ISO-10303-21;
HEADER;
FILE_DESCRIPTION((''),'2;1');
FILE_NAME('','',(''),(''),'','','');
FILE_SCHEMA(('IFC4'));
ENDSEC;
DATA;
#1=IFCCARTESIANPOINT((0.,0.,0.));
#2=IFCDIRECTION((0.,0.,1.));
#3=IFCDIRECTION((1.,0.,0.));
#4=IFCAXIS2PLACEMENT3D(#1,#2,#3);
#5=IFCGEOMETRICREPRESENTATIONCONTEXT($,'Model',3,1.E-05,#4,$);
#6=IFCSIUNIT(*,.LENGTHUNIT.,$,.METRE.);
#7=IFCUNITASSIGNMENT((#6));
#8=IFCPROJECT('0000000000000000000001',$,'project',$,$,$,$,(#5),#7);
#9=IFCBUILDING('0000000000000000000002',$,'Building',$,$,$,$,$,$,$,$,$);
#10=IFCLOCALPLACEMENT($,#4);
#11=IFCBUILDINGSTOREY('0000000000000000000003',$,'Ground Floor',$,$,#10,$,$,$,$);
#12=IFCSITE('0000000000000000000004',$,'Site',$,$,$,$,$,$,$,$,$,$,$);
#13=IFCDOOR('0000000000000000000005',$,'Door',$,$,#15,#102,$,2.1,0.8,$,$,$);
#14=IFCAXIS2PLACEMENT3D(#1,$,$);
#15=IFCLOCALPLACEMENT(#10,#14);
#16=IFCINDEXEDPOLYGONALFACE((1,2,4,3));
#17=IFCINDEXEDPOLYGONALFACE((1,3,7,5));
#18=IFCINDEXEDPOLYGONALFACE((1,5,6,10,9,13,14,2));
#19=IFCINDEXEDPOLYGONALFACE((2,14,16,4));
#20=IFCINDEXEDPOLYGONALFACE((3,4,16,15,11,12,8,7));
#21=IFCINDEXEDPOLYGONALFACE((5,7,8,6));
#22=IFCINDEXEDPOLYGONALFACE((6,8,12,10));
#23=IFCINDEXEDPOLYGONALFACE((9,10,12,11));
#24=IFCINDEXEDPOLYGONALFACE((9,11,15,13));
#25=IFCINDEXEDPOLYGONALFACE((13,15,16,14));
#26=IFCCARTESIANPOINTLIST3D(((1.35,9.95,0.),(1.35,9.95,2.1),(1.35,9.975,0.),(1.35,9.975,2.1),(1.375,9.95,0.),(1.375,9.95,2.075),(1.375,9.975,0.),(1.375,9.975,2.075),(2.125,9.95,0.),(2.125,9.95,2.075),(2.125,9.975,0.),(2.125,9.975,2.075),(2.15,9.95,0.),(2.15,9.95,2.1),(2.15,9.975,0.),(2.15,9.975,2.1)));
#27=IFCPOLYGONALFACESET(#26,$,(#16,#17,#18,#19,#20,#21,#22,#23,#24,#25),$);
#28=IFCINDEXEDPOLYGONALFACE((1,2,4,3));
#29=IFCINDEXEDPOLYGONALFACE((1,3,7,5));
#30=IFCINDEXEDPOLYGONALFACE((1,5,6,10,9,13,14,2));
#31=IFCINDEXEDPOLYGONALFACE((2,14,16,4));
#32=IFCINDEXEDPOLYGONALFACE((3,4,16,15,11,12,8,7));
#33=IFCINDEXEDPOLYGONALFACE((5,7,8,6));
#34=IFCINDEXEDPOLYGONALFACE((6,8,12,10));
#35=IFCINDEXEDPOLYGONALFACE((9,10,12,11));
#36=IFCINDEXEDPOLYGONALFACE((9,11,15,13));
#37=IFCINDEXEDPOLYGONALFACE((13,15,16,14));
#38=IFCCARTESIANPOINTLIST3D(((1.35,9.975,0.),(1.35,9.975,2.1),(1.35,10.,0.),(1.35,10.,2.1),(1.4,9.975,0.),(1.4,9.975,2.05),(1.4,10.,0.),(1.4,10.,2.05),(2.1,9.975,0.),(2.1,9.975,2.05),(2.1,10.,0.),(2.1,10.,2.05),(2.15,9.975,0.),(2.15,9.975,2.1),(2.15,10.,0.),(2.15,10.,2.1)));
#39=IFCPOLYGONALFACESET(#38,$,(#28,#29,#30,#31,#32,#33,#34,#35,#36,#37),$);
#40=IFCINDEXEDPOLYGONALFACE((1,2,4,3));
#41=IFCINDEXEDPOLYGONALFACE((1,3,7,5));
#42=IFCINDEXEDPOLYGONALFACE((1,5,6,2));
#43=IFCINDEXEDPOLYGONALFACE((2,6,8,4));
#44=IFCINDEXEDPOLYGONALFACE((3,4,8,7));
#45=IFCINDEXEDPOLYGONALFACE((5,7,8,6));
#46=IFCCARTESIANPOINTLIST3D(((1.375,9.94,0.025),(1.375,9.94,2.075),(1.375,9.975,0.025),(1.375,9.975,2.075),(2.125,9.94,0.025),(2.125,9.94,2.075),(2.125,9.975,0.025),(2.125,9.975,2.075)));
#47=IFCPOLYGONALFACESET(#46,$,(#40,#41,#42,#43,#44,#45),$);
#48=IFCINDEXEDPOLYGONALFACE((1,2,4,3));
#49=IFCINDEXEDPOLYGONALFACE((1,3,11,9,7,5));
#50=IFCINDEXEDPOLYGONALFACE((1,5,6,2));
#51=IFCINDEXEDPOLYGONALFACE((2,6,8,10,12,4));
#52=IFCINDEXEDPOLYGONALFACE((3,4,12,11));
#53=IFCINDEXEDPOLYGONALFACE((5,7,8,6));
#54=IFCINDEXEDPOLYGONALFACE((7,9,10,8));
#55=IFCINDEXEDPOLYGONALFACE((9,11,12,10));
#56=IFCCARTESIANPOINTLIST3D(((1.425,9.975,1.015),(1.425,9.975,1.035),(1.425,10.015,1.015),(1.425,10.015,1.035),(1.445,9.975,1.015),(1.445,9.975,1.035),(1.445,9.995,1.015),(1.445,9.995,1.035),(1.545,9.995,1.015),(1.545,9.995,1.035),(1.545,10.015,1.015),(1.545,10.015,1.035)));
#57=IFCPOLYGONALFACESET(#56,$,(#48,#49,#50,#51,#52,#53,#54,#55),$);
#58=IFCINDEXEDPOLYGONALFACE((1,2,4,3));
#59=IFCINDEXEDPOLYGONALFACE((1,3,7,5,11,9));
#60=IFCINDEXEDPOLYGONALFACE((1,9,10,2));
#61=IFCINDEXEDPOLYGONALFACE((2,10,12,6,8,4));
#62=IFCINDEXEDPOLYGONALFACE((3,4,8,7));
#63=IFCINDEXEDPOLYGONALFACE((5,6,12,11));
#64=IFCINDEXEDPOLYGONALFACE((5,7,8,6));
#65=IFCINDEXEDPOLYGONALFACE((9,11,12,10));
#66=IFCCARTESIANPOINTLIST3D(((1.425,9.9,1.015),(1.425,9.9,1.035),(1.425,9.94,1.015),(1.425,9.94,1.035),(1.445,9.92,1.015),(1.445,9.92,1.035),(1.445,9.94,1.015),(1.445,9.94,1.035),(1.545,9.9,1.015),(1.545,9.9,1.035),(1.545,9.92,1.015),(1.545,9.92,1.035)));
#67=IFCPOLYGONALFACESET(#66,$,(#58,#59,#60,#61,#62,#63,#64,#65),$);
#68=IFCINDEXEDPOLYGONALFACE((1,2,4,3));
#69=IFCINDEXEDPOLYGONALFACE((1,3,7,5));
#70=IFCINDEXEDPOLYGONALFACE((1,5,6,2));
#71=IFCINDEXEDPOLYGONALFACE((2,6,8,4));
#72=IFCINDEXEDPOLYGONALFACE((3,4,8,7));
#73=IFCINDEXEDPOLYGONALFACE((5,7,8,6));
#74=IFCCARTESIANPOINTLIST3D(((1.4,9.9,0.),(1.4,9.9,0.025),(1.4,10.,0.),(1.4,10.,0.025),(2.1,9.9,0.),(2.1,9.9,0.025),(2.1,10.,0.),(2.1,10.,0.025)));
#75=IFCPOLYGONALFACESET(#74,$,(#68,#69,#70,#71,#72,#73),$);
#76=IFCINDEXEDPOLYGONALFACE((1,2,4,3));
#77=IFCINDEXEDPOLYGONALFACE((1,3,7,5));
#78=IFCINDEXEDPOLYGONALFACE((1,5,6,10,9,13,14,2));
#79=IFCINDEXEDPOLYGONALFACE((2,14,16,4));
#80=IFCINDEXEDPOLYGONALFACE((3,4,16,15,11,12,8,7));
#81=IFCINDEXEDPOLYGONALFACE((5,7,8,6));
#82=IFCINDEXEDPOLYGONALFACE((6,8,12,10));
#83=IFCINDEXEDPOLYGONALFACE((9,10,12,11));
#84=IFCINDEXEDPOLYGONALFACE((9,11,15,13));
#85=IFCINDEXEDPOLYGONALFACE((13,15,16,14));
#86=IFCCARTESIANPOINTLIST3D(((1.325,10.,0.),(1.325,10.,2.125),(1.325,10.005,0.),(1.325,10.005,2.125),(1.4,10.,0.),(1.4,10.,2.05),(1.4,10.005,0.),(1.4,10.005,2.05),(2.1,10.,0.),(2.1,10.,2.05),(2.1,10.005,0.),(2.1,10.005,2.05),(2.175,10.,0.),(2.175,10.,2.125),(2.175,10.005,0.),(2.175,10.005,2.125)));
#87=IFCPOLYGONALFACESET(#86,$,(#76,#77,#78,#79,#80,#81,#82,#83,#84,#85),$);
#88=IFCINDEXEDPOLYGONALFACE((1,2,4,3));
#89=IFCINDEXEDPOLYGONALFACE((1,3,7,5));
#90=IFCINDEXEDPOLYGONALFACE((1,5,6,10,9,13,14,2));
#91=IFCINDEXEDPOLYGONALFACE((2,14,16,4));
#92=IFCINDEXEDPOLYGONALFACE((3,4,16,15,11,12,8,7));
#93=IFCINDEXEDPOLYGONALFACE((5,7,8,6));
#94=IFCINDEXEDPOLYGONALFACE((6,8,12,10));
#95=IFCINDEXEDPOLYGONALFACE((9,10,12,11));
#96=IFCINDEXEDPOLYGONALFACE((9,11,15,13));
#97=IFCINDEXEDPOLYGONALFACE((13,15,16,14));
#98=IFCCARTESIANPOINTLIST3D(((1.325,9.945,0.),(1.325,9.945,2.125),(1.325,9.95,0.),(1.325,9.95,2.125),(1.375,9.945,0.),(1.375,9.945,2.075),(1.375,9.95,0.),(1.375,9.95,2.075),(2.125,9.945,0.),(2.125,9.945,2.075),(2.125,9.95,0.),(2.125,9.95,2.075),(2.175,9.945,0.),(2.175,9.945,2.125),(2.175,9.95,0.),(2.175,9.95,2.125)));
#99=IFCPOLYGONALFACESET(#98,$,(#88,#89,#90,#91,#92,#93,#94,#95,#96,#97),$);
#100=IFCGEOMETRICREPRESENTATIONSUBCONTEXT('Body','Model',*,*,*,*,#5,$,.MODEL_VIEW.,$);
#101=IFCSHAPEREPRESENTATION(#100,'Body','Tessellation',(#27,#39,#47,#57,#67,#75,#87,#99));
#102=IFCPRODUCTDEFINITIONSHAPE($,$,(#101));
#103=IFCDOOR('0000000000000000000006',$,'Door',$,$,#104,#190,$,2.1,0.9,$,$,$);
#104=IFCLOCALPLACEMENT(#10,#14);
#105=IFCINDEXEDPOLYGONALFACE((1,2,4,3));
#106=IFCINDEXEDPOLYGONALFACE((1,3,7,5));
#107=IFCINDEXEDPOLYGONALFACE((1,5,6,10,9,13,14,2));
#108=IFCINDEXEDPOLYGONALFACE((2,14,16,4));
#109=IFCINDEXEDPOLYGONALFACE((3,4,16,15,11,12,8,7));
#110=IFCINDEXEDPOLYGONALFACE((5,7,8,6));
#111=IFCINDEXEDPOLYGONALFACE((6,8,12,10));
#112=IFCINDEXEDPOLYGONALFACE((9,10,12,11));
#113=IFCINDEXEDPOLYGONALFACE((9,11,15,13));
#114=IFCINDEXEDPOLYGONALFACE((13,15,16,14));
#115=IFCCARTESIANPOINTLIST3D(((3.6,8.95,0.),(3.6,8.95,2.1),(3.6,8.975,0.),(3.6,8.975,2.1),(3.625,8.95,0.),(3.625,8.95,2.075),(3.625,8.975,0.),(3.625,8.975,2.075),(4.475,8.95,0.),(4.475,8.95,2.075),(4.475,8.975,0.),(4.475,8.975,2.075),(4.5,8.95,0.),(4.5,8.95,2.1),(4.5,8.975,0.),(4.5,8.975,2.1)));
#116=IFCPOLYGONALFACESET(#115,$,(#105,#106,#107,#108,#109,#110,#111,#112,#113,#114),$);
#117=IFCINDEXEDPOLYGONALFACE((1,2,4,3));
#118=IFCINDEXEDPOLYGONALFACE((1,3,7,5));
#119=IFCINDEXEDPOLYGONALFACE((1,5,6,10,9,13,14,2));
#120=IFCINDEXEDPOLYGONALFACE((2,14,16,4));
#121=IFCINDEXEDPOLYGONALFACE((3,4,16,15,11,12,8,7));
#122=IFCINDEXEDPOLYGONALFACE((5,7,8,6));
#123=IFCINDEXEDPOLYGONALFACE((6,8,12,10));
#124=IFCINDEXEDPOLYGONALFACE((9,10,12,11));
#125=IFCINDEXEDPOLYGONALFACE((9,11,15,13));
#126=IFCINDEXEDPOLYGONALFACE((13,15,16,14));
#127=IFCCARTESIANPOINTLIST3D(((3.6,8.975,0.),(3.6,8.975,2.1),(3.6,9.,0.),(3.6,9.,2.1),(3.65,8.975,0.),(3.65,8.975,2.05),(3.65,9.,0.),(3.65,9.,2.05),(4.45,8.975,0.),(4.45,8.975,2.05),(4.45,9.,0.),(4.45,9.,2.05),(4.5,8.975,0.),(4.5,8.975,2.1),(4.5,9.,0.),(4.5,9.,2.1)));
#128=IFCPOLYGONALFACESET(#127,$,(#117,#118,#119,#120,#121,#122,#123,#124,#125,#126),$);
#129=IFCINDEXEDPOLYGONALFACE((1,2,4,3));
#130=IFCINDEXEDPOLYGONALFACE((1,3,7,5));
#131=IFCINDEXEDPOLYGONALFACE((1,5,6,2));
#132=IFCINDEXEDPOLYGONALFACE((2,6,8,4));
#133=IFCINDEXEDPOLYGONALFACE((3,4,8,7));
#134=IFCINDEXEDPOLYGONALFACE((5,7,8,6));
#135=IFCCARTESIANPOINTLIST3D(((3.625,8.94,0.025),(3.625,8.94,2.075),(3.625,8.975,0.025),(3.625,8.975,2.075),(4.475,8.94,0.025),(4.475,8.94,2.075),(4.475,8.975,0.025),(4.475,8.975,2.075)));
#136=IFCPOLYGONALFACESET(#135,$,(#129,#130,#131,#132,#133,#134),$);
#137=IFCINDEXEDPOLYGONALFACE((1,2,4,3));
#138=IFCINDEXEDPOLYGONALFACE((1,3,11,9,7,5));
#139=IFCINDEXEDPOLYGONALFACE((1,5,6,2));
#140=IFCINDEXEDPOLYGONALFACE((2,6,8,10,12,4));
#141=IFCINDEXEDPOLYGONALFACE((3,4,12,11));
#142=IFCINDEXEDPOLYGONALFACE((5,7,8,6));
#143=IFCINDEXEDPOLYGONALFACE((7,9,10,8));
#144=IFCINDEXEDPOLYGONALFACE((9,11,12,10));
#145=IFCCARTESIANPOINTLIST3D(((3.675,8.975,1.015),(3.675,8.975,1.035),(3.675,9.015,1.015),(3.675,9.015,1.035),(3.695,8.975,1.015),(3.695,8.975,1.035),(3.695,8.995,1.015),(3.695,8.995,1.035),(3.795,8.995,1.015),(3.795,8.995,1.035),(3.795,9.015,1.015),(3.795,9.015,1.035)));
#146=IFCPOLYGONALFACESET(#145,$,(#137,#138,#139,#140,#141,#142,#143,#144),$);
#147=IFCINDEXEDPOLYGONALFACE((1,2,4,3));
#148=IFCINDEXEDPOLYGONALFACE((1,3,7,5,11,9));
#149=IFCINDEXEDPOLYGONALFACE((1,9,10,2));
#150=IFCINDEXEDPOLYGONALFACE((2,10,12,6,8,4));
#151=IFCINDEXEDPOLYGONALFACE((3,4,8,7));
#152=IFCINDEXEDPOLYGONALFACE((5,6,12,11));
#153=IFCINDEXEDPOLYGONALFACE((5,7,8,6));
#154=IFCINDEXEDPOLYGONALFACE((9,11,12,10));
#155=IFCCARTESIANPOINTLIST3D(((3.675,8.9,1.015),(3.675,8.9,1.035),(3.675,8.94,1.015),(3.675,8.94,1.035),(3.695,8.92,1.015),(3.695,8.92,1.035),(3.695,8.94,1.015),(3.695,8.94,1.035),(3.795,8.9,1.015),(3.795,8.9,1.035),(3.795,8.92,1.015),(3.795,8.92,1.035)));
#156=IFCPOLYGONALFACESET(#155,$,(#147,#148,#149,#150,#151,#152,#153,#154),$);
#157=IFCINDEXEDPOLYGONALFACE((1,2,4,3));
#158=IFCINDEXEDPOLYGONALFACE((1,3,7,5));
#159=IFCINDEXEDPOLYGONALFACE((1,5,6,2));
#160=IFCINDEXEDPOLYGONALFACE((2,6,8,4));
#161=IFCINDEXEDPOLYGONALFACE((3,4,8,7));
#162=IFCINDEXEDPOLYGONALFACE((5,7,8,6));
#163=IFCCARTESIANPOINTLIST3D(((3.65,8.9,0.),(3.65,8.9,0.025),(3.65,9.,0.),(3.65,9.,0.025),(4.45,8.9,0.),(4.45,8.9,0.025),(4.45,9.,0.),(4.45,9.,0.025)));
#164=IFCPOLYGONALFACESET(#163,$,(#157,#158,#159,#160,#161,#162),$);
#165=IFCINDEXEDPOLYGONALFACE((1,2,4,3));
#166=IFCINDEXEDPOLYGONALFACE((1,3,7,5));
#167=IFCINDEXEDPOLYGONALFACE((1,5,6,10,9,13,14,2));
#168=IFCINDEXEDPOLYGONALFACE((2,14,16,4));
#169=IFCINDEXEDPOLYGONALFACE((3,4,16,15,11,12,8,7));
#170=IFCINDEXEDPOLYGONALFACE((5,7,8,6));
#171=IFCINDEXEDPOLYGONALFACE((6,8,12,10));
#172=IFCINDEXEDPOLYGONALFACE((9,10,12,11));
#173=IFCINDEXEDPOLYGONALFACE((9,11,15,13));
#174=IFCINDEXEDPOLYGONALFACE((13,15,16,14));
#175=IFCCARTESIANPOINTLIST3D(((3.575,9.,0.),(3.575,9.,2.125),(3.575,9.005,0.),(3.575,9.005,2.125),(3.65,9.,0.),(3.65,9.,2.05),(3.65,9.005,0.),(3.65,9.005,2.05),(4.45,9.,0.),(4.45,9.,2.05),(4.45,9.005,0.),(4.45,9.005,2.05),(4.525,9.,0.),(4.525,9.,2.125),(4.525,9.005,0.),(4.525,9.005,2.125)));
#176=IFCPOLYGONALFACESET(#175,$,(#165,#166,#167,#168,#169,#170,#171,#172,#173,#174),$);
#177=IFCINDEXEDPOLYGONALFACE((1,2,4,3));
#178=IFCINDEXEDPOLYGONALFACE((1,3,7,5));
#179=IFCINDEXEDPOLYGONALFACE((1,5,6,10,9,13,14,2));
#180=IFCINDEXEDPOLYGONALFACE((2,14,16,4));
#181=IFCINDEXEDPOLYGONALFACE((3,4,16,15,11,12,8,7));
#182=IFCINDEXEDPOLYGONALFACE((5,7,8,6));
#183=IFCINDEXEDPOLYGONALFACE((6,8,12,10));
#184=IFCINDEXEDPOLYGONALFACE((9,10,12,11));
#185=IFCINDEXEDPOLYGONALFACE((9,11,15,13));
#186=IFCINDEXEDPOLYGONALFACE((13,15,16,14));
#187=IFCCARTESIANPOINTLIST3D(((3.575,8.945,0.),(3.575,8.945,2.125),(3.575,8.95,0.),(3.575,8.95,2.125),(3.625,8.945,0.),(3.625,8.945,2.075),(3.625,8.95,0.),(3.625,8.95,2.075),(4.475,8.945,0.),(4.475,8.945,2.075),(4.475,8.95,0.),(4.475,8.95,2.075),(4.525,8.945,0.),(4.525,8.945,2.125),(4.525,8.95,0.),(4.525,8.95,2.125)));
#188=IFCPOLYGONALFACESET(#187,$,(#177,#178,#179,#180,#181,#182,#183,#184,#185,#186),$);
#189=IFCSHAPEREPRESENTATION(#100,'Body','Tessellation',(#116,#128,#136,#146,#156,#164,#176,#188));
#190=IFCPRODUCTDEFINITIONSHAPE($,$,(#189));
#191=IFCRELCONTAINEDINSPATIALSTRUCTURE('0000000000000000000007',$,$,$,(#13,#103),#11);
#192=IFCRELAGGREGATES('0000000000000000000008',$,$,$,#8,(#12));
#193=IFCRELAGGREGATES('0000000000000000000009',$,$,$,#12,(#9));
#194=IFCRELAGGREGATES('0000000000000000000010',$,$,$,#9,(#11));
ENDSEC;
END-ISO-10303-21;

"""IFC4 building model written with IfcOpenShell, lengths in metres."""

from ifc_helpers import new_model, si_unit, frame, origin_with_axes, place, context, subcontext, project, spatial, line, indexed_curve, outline, extrude, element, save


model = new_model("IFC4")

# Units and contexts
model_context = context("Model", 3, precision=1e-05, world=origin_with_axes())
body_context = subcontext(model_context, "Body", "Model", "MODEL_VIEW")
ifc_project = project(units=[si_unit("LENGTHUNIT", "METRE")], contexts=[model_context])

# Site, building, storey
site = spatial("IfcSite", under=ifc_project, Name="Site")
building = spatial("IfcBuilding", under=site, Name="Building")
storey_placement = place(None, origin_with_axes())
storey = spatial("IfcBuildingStorey", under=building, at=storey_placement, Name="Ground Floor")

# Doors
door_1_placement = place(storey_placement, frame((2.15, 10.0, 0.0), z_axis=(0.0, 0.0, 1.0), x_axis=(-1.0, 0.0, 0.0)))
element("IfcDoor", 1, at=door_1_placement, inside=storey, Name="Door", OverallHeight=2.1, OverallWidth=0.8, context=body_context, shape_type="SweptSolid", body=[
    extrude(outline(indexed_curve([(0.0, 0.0), (0.0, 2.1), (0.8, 2.1), (0.8, 0.0), (0.775, 0.0), (0.775, 2.075), (0.025, 2.075), (0.025, 0.0)], segments=[line(1, 2, 3, 4, 5, 6, 7, 8, 1)])), frame((0.0, 0.025, 0.0), z_axis=(0.0, -1.0, 0.0), x_axis=(1.0, 0.0, 0.0)), (0.0, 0.0, -1.0), 0.025),
    extrude(outline(indexed_curve([(0.0, 0.0), (0.0, 2.1), (0.8, 2.1), (0.8, 0.0), (0.75, 0.0), (0.75, 2.05), (0.05, 2.05), (0.05, 0.0)], segments=[line(1, 2, 3, 4, 5, 6, 7, 8, 1)])), frame((0.0, 0.0, 0.0), z_axis=(0.0, -1.0, 0.0), x_axis=(1.0, 0.0, 0.0)), (0.0, 0.0, -1.0), 0.025),
    extrude(outline(indexed_curve([(0.0, 0.0), (0.75, 0.0), (0.75, 0.035), (0.0, 0.035)], segments=[line(1, 2, 3, 4, 1)])), frame((0.025, 0.025, 0.025), z_axis=(0.0, 0.0, 1.0), x_axis=(1.0, 0.0, 0.0)), (0.0, 0.0, 1.0), 2.05),
    extrude(outline(indexed_curve([(0.0, 0.0), (0.0, -0.04), (-0.12, -0.04), (-0.12, -0.02), (-0.02, -0.02), (-0.02, 0.0)], segments=[line(1, 2, 3, 4, 5, 6, 1)])), frame((0.725, 0.025, 1.015), z_axis=(0.0, 0.0, 1.0), x_axis=(1.0, 0.0, 0.0)), (0.0, 0.0, 1.0), 0.02),
    extrude(outline(indexed_curve([(0.0, 0.0), (0.0, 0.04), (-0.12, 0.04), (-0.12, 0.02), (-0.02, 0.02), (-0.02, 0.0)], segments=[line(1, 2, 3, 4, 5, 6, 1)])), frame((0.725, 0.06, 1.015), z_axis=(0.0, 0.0, 1.0), x_axis=(1.0, 0.0, 0.0)), (0.0, 0.0, 1.0), 0.02),
    extrude(outline(indexed_curve([(0.0, 0.0), (0.7, 0.0), (0.7, 0.1), (0.0, 0.1)], segments=[line(1, 2, 3, 4, 1)])), frame((0.05, 0.0, 0.0), z_axis=(0.0, 0.0, 1.0), x_axis=(1.0, 0.0, 0.0)), (0.0, 0.0, 1.0), 0.025),
    extrude(outline(indexed_curve([(0.0, 0.0), (0.0, 2.125), (0.85, 2.125), (0.85, 0.0), (0.775, 0.0), (0.775, 2.05), (0.075, 2.05), (0.075, 0.0)], segments=[line(1, 2, 3, 4, 5, 6, 7, 8, 1)])), frame((-0.025, -0.005, 0.0), z_axis=(0.0, -1.0, 0.0), x_axis=(1.0, 0.0, 0.0)), (0.0, 0.0, -1.0), 0.005),
    extrude(outline(indexed_curve([(0.0, 0.0), (0.0, 2.125), (0.85, 2.125), (0.85, 0.0), (0.8, 0.0), (0.8, 2.075), (0.05, 2.075), (0.05, 0.0)], segments=[line(1, 2, 3, 4, 5, 6, 7, 8, 1)])), frame((-0.025, 0.05, 0.0), z_axis=(0.0, -1.0, 0.0), x_axis=(1.0, 0.0, 0.0)), (0.0, 0.0, -1.0), 0.005),
])
door_2_placement = place(storey_placement, frame((4.5, 9.0, 0.0), z_axis=(0.0, 0.0, 1.0), x_axis=(-1.0, 0.0, 0.0)))
element("IfcDoor", 2, at=door_2_placement, inside=storey, Name="Door", OverallHeight=2.1, OverallWidth=0.9, context=body_context, shape_type="SweptSolid", body=[
    extrude(outline(indexed_curve([(0.0, 0.0), (0.0, 2.1), (0.9, 2.1), (0.9, 0.0), (0.875, 0.0), (0.875, 2.075), (0.025, 2.075), (0.025, 0.0)], segments=[line(1, 2, 3, 4, 5, 6, 7, 8, 1)])), frame((0.0, 0.025, 0.0), z_axis=(0.0, -1.0, 0.0), x_axis=(1.0, 0.0, 0.0)), (0.0, 0.0, -1.0), 0.025),
    extrude(outline(indexed_curve([(0.0, 0.0), (0.0, 2.1), (0.9, 2.1), (0.9, 0.0), (0.85, 0.0), (0.85, 2.05), (0.05, 2.05), (0.05, 0.0)], segments=[line(1, 2, 3, 4, 5, 6, 7, 8, 1)])), frame((0.0, 0.0, 0.0), z_axis=(0.0, -1.0, 0.0), x_axis=(1.0, 0.0, 0.0)), (0.0, 0.0, -1.0), 0.025),
    extrude(outline(indexed_curve([(0.0, 0.0), (0.85, 0.0), (0.85, 0.035), (0.0, 0.035)], segments=[line(1, 2, 3, 4, 1)])), frame((0.025, 0.025, 0.025), z_axis=(0.0, 0.0, 1.0), x_axis=(1.0, 0.0, 0.0)), (0.0, 0.0, 1.0), 2.05),
    extrude(outline(indexed_curve([(0.0, 0.0), (0.0, -0.04), (-0.12, -0.04), (-0.12, -0.02), (-0.02, -0.02), (-0.02, 0.0)], segments=[line(1, 2, 3, 4, 5, 6, 1)])), frame((0.825, 0.025, 1.015), z_axis=(0.0, 0.0, 1.0), x_axis=(1.0, 0.0, 0.0)), (0.0, 0.0, 1.0), 0.02),
    extrude(outline(indexed_curve([(0.0, 0.0), (0.0, 0.04), (-0.12, 0.04), (-0.12, 0.02), (-0.02, 0.02), (-0.02, 0.0)], segments=[line(1, 2, 3, 4, 5, 6, 1)])), frame((0.825, 0.06, 1.015), z_axis=(0.0, 0.0, 1.0), x_axis=(1.0, 0.0, 0.0)), (0.0, 0.0, 1.0), 0.02),
    extrude(outline(indexed_curve([(0.0, 0.0), (0.8, 0.0), (0.8, 0.1), (0.0, 0.1)], segments=[line(1, 2, 3, 4, 1)])), frame((0.05, 0.0, 0.0), z_axis=(0.0, 0.0, 1.0), x_axis=(1.0, 0.0, 0.0)), (0.0, 0.0, 1.0), 0.025),
    extrude(outline(indexed_curve([(0.0, 0.0), (0.0, 2.125), (0.95, 2.125), (0.95, 0.0), (0.875, 0.0), (0.875, 2.05), (0.075, 2.05), (0.075, 0.0)], segments=[line(1, 2, 3, 4, 5, 6, 7, 8, 1)])), frame((-0.025, -0.005, 0.0), z_axis=(0.0, -1.0, 0.0), x_axis=(1.0, 0.0, 0.0)), (0.0, 0.0, -1.0), 0.005),
    extrude(outline(indexed_curve([(0.0, 0.0), (0.0, 2.125), (0.95, 2.125), (0.95, 0.0), (0.9, 0.0), (0.9, 2.075), (0.05, 2.075), (0.05, 0.0)], segments=[line(1, 2, 3, 4, 5, 6, 7, 8, 1)])), frame((-0.025, 0.05, 0.0), z_axis=(0.0, -1.0, 0.0), x_axis=(1.0, 0.0, 0.0)), (0.0, 0.0, -1.0), 0.005),
])

save(model, "model.ifc")
